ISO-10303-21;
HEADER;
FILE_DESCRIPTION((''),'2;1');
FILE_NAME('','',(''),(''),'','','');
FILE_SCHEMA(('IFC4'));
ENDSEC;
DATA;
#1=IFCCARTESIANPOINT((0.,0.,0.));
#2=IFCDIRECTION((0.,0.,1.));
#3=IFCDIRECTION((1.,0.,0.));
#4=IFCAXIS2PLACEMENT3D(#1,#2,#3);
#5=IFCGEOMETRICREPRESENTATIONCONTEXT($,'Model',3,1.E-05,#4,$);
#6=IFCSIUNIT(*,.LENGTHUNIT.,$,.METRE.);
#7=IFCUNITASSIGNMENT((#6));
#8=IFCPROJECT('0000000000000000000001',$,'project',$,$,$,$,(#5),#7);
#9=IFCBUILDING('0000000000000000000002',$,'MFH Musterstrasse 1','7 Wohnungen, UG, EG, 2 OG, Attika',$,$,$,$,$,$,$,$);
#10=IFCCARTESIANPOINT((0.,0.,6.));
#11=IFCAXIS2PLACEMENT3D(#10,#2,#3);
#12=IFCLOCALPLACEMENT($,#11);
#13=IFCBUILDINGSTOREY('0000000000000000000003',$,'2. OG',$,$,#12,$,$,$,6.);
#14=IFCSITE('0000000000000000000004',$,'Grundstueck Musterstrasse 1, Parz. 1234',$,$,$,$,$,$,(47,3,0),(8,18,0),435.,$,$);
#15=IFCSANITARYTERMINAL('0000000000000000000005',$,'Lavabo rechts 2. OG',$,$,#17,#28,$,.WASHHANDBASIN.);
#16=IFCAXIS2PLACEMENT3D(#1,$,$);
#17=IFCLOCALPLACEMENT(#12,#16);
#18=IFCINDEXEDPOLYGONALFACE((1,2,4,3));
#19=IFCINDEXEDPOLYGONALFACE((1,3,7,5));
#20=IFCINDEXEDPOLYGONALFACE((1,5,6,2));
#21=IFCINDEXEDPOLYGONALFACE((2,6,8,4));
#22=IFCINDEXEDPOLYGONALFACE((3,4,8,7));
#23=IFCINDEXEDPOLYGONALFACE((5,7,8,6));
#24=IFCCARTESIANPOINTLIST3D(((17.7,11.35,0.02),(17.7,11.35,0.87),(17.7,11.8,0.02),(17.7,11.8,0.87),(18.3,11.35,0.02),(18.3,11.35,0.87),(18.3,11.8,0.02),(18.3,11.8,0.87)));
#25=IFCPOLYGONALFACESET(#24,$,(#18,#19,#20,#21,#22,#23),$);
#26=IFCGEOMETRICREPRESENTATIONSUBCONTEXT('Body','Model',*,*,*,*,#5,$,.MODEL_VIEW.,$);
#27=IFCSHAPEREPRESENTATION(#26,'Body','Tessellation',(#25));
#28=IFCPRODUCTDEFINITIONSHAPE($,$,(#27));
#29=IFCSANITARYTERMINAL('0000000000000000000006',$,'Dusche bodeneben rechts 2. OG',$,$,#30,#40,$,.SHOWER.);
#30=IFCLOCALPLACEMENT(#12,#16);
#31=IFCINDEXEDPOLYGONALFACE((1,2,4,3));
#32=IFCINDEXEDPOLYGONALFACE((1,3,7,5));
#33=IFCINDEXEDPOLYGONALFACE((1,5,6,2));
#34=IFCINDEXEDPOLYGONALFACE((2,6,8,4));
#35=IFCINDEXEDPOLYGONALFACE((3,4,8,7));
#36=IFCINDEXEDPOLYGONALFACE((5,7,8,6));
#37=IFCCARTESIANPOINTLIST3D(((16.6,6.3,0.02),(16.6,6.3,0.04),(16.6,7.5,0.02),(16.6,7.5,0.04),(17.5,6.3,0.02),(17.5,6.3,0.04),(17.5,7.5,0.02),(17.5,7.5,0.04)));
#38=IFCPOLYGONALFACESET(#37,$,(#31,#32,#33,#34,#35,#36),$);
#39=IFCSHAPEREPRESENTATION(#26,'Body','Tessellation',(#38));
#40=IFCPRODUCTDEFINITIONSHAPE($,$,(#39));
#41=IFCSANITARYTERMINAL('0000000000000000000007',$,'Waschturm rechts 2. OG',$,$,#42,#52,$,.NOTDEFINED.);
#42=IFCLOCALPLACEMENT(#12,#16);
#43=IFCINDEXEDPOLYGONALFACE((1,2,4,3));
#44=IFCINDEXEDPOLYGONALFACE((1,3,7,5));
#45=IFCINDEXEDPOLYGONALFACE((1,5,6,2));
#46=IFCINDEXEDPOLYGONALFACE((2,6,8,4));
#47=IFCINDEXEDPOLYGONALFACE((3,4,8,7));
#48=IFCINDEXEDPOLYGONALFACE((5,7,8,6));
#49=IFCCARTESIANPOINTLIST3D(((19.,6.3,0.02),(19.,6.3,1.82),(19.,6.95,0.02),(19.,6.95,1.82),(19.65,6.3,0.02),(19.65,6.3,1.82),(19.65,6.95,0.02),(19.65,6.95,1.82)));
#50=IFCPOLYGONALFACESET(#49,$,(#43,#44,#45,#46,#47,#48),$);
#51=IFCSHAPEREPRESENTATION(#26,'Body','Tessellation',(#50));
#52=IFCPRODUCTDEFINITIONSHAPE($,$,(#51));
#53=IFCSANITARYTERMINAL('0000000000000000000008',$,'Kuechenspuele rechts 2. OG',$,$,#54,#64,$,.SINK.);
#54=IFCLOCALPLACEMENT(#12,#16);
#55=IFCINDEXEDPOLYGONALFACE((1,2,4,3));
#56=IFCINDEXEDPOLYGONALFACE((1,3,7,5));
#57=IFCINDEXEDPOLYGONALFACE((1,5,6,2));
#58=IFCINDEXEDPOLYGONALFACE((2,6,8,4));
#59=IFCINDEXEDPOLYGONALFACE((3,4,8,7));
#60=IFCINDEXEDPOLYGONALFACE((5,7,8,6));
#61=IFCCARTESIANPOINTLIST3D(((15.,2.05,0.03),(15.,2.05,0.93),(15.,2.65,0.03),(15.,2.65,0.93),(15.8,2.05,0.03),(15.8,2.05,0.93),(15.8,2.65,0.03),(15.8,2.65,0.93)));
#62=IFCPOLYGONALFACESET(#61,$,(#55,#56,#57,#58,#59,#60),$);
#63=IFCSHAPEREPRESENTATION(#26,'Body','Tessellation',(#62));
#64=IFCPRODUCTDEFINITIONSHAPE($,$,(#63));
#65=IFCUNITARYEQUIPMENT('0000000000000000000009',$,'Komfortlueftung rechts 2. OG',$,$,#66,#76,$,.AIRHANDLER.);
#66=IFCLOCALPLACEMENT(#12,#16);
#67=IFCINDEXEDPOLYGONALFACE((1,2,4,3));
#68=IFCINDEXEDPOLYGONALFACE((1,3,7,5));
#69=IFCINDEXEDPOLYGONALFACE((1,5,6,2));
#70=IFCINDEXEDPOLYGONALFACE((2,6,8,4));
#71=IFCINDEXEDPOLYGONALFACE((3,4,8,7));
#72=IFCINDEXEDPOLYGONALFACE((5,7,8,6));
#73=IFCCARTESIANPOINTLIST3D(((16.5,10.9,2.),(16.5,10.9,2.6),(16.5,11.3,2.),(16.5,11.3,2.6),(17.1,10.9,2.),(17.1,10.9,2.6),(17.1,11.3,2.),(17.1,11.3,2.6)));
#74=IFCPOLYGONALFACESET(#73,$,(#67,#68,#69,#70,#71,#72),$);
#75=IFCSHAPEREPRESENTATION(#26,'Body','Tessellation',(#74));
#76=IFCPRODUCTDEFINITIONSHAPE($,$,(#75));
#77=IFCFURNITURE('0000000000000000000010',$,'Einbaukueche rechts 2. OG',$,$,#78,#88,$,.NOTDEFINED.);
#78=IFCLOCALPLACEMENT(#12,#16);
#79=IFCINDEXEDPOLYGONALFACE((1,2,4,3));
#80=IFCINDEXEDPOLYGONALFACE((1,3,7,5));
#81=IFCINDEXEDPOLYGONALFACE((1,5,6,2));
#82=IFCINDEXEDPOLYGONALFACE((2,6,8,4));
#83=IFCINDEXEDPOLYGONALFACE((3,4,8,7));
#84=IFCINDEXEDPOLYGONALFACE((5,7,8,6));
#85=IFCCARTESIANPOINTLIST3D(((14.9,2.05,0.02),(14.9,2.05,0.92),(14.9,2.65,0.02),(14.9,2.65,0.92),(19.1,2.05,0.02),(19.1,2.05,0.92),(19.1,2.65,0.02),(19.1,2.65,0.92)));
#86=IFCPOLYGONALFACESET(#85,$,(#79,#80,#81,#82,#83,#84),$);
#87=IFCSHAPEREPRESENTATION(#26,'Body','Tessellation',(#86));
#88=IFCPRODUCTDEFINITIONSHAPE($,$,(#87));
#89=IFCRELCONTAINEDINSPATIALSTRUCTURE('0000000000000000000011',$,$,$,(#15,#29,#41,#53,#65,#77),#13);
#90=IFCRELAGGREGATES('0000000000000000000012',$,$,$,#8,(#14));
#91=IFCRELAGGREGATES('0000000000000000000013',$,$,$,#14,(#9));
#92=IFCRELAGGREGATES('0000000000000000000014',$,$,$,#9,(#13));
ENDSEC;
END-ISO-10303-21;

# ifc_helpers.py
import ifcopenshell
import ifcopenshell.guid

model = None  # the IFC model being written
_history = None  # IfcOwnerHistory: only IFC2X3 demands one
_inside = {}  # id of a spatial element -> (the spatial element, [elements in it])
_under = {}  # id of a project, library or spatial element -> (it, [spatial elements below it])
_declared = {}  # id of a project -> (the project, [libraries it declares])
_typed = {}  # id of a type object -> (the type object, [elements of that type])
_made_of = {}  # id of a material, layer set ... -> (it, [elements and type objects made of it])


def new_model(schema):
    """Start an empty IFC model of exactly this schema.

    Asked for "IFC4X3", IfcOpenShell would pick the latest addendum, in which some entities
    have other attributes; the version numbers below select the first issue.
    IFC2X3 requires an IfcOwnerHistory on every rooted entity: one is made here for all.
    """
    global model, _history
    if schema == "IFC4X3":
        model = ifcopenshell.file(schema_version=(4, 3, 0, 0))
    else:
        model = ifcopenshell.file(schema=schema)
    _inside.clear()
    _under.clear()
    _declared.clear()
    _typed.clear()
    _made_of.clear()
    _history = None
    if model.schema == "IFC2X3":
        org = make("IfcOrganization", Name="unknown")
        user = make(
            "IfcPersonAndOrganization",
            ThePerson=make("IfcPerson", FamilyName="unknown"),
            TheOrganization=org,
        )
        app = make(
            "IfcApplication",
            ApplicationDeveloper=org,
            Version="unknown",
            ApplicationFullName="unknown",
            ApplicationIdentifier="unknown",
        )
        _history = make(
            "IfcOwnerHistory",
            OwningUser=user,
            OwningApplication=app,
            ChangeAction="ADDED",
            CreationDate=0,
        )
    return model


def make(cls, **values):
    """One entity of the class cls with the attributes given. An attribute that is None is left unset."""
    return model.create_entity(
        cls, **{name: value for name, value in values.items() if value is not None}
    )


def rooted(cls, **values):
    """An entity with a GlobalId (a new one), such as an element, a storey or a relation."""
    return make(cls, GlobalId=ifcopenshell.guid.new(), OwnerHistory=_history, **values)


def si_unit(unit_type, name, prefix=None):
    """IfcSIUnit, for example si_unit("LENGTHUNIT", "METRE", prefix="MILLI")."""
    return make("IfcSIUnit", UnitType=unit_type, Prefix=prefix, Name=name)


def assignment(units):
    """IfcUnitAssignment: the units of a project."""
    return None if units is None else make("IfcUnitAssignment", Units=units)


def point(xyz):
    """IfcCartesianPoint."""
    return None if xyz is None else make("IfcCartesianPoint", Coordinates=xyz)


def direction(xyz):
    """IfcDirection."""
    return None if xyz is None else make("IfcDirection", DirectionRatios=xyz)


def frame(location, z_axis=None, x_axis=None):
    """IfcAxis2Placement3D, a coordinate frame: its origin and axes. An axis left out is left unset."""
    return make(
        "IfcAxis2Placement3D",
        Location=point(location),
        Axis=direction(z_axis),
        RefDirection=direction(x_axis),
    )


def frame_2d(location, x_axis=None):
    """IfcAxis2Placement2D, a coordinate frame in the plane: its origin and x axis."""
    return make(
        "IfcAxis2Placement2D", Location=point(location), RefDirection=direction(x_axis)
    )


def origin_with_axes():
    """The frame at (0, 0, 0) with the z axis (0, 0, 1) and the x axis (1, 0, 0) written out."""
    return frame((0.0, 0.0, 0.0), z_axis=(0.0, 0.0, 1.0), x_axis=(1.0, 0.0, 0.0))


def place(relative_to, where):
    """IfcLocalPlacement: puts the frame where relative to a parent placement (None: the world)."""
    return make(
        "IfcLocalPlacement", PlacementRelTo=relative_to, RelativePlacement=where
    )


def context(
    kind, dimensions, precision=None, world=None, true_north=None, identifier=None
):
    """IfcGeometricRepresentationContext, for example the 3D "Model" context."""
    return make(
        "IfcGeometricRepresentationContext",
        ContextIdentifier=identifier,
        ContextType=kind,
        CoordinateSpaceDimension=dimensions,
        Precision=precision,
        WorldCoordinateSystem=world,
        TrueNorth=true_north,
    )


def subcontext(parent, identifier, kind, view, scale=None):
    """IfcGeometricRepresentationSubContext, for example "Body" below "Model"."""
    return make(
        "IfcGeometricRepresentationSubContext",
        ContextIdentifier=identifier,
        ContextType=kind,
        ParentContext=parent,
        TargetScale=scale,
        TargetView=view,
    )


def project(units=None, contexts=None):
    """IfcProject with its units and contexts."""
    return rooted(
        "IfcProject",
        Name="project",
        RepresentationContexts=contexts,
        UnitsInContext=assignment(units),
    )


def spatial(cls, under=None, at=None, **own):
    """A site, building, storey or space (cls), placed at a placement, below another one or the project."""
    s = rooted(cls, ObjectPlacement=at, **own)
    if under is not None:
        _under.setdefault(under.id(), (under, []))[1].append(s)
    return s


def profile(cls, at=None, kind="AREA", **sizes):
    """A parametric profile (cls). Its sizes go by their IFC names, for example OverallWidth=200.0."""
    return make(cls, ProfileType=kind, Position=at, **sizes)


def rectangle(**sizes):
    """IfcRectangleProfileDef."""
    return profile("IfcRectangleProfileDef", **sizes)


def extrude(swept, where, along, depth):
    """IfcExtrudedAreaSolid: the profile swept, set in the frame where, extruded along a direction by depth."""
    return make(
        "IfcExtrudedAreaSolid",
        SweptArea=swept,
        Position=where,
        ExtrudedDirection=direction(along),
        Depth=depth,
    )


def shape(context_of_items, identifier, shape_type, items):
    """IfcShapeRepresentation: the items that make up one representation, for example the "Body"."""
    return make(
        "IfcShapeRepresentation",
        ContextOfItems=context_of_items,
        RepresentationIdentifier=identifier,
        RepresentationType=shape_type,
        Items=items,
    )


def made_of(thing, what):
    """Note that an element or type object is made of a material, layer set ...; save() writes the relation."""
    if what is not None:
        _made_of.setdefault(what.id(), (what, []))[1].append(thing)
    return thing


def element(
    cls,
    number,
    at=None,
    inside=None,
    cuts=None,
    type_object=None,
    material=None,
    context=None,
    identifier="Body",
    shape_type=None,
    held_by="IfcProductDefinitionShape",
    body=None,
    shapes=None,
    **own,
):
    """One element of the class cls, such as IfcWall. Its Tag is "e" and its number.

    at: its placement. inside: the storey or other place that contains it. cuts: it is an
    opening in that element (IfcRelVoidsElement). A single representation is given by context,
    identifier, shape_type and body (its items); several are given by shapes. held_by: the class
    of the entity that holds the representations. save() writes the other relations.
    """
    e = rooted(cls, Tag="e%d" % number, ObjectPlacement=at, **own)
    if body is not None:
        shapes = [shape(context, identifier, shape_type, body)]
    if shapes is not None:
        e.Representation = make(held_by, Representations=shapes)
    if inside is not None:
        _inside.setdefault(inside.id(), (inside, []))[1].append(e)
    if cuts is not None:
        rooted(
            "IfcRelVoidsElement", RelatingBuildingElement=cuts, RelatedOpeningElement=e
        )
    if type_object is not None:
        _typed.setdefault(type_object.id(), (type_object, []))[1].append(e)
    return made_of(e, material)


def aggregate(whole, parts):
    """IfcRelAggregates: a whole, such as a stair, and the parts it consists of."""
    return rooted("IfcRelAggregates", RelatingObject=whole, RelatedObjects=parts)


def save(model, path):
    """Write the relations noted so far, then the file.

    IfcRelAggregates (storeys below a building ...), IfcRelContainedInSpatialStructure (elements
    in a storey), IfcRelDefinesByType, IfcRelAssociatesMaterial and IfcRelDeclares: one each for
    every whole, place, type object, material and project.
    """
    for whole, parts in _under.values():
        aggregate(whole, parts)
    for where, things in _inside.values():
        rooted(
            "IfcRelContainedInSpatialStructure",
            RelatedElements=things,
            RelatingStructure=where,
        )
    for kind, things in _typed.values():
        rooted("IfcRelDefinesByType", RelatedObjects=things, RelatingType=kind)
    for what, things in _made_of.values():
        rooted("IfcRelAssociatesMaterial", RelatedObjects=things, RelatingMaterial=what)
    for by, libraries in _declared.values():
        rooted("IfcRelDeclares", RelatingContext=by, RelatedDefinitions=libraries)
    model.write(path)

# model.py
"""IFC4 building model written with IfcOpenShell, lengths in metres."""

from ifc_helpers import new_model, si_unit, frame, frame_2d, origin_with_axes, place, context, subcontext, project, spatial, rectangle, extrude, element, save


model = new_model("IFC4")

# Units and contexts
model_context = context("Model", 3, precision=1e-05, world=origin_with_axes())
body_context = subcontext(model_context, "Body", "Model", "MODEL_VIEW")
ifc_project = project(units=[si_unit("LENGTHUNIT", "METRE")], contexts=[model_context])

# Site, building, storey
site = spatial("IfcSite", under=ifc_project, Name="Grundstueck Musterstrasse 1, Parz. 1234", RefLatitude=(47, 3, 0), RefLongitude=(8, 18, 0), RefElevation=435.0)
building = spatial("IfcBuilding", under=site, Name="MFH Musterstrasse 1", Description="7 Wohnungen, UG, EG, 2 OG, Attika")
storey_placement = place(None, frame((0.0, 0.0, 6.0), z_axis=(0.0, 0.0, 1.0), x_axis=(1.0, 0.0, 0.0)))
storey = spatial("IfcBuildingStorey", under=building, at=storey_placement, Name="2. OG", Elevation=6.0)

# Sanitary terminals
sanitary_terminal_1_placement = place(storey_placement, frame((17.7, 11.35, 0.02), z_axis=(0.0, 0.0, 1.0), x_axis=(1.0, 0.0, 0.0)))
element("IfcSanitaryTerminal", 1, at=sanitary_terminal_1_placement, inside=storey, Name="Lavabo rechts 2. OG", PredefinedType="WASHHANDBASIN", context=body_context, shape_type="SweptSolid", body=[
    extrude(rectangle(XDim=0.6, YDim=0.45, at=frame_2d((0.3, 0.225))), origin_with_axes(), (0.0, 0.0, 1.0), 0.85),
])
sanitary_terminal_2_placement = place(storey_placement, frame((16.6, 6.3, 0.02), z_axis=(0.0, 0.0, 1.0), x_axis=(1.0, 0.0, 0.0)))
element("IfcSanitaryTerminal", 2, at=sanitary_terminal_2_placement, inside=storey, Name="Dusche bodeneben rechts 2. OG", PredefinedType="SHOWER", context=body_context, shape_type="SweptSolid", body=[
    extrude(rectangle(XDim=0.9, YDim=1.2, at=frame_2d((0.45, 0.6))), origin_with_axes(), (0.0, 0.0, 1.0), 0.02),
])
sanitary_terminal_3_placement = place(storey_placement, frame((19.0, 6.3, 0.02), z_axis=(0.0, 0.0, 1.0), x_axis=(1.0, 0.0, 0.0)))
element("IfcSanitaryTerminal", 3, at=sanitary_terminal_3_placement, inside=storey, Name="Waschturm rechts 2. OG", PredefinedType="NOTDEFINED", context=body_context, shape_type="SweptSolid", body=[
    extrude(rectangle(XDim=0.65, YDim=0.65, at=frame_2d((0.325, 0.325))), origin_with_axes(), (0.0, 0.0, 1.0), 1.8),
])
sanitary_terminal_4_placement = place(storey_placement, frame((15.0, 2.05, 0.03), z_axis=(0.0, 0.0, 1.0), x_axis=(1.0, 0.0, 0.0)))
element("IfcSanitaryTerminal", 4, at=sanitary_terminal_4_placement, inside=storey, Name="Kuechenspuele rechts 2. OG", PredefinedType="SINK", context=body_context, shape_type="SweptSolid", body=[
    extrude(rectangle(XDim=0.8, YDim=0.6, at=frame_2d((0.4, 0.3))), origin_with_axes(), (0.0, 0.0, 1.0), 0.9),
])

# Unitary equipment
unitary_equipment_placement = place(storey_placement, frame((16.5, 10.9, 2.0), z_axis=(0.0, 0.0, 1.0), x_axis=(1.0, 0.0, 0.0)))
element("IfcUnitaryEquipment", 5, at=unitary_equipment_placement, inside=storey, Name="Komfortlueftung rechts 2. OG", PredefinedType="AIRHANDLER", context=body_context, shape_type="SweptSolid", body=[
    extrude(rectangle(XDim=0.6, YDim=0.4, at=frame_2d((0.3, 0.2))), origin_with_axes(), (0.0, 0.0, 1.0), 0.6),
])

# Furniture
furniture_placement = place(storey_placement, frame((14.9, 2.05, 0.02), z_axis=(0.0, 0.0, 1.0), x_axis=(1.0, 0.0, 0.0)))
element("IfcFurniture", 6, at=furniture_placement, inside=storey, Name="Einbaukueche rechts 2. OG", PredefinedType="NOTDEFINED", context=body_context, shape_type="SweptSolid", body=[
    extrude(rectangle(XDim=4.2, YDim=0.6, at=frame_2d((2.1, 0.3))), origin_with_axes(), (0.0, 0.0, 1.0), 0.9),
])

save(model, "model.ifc")
